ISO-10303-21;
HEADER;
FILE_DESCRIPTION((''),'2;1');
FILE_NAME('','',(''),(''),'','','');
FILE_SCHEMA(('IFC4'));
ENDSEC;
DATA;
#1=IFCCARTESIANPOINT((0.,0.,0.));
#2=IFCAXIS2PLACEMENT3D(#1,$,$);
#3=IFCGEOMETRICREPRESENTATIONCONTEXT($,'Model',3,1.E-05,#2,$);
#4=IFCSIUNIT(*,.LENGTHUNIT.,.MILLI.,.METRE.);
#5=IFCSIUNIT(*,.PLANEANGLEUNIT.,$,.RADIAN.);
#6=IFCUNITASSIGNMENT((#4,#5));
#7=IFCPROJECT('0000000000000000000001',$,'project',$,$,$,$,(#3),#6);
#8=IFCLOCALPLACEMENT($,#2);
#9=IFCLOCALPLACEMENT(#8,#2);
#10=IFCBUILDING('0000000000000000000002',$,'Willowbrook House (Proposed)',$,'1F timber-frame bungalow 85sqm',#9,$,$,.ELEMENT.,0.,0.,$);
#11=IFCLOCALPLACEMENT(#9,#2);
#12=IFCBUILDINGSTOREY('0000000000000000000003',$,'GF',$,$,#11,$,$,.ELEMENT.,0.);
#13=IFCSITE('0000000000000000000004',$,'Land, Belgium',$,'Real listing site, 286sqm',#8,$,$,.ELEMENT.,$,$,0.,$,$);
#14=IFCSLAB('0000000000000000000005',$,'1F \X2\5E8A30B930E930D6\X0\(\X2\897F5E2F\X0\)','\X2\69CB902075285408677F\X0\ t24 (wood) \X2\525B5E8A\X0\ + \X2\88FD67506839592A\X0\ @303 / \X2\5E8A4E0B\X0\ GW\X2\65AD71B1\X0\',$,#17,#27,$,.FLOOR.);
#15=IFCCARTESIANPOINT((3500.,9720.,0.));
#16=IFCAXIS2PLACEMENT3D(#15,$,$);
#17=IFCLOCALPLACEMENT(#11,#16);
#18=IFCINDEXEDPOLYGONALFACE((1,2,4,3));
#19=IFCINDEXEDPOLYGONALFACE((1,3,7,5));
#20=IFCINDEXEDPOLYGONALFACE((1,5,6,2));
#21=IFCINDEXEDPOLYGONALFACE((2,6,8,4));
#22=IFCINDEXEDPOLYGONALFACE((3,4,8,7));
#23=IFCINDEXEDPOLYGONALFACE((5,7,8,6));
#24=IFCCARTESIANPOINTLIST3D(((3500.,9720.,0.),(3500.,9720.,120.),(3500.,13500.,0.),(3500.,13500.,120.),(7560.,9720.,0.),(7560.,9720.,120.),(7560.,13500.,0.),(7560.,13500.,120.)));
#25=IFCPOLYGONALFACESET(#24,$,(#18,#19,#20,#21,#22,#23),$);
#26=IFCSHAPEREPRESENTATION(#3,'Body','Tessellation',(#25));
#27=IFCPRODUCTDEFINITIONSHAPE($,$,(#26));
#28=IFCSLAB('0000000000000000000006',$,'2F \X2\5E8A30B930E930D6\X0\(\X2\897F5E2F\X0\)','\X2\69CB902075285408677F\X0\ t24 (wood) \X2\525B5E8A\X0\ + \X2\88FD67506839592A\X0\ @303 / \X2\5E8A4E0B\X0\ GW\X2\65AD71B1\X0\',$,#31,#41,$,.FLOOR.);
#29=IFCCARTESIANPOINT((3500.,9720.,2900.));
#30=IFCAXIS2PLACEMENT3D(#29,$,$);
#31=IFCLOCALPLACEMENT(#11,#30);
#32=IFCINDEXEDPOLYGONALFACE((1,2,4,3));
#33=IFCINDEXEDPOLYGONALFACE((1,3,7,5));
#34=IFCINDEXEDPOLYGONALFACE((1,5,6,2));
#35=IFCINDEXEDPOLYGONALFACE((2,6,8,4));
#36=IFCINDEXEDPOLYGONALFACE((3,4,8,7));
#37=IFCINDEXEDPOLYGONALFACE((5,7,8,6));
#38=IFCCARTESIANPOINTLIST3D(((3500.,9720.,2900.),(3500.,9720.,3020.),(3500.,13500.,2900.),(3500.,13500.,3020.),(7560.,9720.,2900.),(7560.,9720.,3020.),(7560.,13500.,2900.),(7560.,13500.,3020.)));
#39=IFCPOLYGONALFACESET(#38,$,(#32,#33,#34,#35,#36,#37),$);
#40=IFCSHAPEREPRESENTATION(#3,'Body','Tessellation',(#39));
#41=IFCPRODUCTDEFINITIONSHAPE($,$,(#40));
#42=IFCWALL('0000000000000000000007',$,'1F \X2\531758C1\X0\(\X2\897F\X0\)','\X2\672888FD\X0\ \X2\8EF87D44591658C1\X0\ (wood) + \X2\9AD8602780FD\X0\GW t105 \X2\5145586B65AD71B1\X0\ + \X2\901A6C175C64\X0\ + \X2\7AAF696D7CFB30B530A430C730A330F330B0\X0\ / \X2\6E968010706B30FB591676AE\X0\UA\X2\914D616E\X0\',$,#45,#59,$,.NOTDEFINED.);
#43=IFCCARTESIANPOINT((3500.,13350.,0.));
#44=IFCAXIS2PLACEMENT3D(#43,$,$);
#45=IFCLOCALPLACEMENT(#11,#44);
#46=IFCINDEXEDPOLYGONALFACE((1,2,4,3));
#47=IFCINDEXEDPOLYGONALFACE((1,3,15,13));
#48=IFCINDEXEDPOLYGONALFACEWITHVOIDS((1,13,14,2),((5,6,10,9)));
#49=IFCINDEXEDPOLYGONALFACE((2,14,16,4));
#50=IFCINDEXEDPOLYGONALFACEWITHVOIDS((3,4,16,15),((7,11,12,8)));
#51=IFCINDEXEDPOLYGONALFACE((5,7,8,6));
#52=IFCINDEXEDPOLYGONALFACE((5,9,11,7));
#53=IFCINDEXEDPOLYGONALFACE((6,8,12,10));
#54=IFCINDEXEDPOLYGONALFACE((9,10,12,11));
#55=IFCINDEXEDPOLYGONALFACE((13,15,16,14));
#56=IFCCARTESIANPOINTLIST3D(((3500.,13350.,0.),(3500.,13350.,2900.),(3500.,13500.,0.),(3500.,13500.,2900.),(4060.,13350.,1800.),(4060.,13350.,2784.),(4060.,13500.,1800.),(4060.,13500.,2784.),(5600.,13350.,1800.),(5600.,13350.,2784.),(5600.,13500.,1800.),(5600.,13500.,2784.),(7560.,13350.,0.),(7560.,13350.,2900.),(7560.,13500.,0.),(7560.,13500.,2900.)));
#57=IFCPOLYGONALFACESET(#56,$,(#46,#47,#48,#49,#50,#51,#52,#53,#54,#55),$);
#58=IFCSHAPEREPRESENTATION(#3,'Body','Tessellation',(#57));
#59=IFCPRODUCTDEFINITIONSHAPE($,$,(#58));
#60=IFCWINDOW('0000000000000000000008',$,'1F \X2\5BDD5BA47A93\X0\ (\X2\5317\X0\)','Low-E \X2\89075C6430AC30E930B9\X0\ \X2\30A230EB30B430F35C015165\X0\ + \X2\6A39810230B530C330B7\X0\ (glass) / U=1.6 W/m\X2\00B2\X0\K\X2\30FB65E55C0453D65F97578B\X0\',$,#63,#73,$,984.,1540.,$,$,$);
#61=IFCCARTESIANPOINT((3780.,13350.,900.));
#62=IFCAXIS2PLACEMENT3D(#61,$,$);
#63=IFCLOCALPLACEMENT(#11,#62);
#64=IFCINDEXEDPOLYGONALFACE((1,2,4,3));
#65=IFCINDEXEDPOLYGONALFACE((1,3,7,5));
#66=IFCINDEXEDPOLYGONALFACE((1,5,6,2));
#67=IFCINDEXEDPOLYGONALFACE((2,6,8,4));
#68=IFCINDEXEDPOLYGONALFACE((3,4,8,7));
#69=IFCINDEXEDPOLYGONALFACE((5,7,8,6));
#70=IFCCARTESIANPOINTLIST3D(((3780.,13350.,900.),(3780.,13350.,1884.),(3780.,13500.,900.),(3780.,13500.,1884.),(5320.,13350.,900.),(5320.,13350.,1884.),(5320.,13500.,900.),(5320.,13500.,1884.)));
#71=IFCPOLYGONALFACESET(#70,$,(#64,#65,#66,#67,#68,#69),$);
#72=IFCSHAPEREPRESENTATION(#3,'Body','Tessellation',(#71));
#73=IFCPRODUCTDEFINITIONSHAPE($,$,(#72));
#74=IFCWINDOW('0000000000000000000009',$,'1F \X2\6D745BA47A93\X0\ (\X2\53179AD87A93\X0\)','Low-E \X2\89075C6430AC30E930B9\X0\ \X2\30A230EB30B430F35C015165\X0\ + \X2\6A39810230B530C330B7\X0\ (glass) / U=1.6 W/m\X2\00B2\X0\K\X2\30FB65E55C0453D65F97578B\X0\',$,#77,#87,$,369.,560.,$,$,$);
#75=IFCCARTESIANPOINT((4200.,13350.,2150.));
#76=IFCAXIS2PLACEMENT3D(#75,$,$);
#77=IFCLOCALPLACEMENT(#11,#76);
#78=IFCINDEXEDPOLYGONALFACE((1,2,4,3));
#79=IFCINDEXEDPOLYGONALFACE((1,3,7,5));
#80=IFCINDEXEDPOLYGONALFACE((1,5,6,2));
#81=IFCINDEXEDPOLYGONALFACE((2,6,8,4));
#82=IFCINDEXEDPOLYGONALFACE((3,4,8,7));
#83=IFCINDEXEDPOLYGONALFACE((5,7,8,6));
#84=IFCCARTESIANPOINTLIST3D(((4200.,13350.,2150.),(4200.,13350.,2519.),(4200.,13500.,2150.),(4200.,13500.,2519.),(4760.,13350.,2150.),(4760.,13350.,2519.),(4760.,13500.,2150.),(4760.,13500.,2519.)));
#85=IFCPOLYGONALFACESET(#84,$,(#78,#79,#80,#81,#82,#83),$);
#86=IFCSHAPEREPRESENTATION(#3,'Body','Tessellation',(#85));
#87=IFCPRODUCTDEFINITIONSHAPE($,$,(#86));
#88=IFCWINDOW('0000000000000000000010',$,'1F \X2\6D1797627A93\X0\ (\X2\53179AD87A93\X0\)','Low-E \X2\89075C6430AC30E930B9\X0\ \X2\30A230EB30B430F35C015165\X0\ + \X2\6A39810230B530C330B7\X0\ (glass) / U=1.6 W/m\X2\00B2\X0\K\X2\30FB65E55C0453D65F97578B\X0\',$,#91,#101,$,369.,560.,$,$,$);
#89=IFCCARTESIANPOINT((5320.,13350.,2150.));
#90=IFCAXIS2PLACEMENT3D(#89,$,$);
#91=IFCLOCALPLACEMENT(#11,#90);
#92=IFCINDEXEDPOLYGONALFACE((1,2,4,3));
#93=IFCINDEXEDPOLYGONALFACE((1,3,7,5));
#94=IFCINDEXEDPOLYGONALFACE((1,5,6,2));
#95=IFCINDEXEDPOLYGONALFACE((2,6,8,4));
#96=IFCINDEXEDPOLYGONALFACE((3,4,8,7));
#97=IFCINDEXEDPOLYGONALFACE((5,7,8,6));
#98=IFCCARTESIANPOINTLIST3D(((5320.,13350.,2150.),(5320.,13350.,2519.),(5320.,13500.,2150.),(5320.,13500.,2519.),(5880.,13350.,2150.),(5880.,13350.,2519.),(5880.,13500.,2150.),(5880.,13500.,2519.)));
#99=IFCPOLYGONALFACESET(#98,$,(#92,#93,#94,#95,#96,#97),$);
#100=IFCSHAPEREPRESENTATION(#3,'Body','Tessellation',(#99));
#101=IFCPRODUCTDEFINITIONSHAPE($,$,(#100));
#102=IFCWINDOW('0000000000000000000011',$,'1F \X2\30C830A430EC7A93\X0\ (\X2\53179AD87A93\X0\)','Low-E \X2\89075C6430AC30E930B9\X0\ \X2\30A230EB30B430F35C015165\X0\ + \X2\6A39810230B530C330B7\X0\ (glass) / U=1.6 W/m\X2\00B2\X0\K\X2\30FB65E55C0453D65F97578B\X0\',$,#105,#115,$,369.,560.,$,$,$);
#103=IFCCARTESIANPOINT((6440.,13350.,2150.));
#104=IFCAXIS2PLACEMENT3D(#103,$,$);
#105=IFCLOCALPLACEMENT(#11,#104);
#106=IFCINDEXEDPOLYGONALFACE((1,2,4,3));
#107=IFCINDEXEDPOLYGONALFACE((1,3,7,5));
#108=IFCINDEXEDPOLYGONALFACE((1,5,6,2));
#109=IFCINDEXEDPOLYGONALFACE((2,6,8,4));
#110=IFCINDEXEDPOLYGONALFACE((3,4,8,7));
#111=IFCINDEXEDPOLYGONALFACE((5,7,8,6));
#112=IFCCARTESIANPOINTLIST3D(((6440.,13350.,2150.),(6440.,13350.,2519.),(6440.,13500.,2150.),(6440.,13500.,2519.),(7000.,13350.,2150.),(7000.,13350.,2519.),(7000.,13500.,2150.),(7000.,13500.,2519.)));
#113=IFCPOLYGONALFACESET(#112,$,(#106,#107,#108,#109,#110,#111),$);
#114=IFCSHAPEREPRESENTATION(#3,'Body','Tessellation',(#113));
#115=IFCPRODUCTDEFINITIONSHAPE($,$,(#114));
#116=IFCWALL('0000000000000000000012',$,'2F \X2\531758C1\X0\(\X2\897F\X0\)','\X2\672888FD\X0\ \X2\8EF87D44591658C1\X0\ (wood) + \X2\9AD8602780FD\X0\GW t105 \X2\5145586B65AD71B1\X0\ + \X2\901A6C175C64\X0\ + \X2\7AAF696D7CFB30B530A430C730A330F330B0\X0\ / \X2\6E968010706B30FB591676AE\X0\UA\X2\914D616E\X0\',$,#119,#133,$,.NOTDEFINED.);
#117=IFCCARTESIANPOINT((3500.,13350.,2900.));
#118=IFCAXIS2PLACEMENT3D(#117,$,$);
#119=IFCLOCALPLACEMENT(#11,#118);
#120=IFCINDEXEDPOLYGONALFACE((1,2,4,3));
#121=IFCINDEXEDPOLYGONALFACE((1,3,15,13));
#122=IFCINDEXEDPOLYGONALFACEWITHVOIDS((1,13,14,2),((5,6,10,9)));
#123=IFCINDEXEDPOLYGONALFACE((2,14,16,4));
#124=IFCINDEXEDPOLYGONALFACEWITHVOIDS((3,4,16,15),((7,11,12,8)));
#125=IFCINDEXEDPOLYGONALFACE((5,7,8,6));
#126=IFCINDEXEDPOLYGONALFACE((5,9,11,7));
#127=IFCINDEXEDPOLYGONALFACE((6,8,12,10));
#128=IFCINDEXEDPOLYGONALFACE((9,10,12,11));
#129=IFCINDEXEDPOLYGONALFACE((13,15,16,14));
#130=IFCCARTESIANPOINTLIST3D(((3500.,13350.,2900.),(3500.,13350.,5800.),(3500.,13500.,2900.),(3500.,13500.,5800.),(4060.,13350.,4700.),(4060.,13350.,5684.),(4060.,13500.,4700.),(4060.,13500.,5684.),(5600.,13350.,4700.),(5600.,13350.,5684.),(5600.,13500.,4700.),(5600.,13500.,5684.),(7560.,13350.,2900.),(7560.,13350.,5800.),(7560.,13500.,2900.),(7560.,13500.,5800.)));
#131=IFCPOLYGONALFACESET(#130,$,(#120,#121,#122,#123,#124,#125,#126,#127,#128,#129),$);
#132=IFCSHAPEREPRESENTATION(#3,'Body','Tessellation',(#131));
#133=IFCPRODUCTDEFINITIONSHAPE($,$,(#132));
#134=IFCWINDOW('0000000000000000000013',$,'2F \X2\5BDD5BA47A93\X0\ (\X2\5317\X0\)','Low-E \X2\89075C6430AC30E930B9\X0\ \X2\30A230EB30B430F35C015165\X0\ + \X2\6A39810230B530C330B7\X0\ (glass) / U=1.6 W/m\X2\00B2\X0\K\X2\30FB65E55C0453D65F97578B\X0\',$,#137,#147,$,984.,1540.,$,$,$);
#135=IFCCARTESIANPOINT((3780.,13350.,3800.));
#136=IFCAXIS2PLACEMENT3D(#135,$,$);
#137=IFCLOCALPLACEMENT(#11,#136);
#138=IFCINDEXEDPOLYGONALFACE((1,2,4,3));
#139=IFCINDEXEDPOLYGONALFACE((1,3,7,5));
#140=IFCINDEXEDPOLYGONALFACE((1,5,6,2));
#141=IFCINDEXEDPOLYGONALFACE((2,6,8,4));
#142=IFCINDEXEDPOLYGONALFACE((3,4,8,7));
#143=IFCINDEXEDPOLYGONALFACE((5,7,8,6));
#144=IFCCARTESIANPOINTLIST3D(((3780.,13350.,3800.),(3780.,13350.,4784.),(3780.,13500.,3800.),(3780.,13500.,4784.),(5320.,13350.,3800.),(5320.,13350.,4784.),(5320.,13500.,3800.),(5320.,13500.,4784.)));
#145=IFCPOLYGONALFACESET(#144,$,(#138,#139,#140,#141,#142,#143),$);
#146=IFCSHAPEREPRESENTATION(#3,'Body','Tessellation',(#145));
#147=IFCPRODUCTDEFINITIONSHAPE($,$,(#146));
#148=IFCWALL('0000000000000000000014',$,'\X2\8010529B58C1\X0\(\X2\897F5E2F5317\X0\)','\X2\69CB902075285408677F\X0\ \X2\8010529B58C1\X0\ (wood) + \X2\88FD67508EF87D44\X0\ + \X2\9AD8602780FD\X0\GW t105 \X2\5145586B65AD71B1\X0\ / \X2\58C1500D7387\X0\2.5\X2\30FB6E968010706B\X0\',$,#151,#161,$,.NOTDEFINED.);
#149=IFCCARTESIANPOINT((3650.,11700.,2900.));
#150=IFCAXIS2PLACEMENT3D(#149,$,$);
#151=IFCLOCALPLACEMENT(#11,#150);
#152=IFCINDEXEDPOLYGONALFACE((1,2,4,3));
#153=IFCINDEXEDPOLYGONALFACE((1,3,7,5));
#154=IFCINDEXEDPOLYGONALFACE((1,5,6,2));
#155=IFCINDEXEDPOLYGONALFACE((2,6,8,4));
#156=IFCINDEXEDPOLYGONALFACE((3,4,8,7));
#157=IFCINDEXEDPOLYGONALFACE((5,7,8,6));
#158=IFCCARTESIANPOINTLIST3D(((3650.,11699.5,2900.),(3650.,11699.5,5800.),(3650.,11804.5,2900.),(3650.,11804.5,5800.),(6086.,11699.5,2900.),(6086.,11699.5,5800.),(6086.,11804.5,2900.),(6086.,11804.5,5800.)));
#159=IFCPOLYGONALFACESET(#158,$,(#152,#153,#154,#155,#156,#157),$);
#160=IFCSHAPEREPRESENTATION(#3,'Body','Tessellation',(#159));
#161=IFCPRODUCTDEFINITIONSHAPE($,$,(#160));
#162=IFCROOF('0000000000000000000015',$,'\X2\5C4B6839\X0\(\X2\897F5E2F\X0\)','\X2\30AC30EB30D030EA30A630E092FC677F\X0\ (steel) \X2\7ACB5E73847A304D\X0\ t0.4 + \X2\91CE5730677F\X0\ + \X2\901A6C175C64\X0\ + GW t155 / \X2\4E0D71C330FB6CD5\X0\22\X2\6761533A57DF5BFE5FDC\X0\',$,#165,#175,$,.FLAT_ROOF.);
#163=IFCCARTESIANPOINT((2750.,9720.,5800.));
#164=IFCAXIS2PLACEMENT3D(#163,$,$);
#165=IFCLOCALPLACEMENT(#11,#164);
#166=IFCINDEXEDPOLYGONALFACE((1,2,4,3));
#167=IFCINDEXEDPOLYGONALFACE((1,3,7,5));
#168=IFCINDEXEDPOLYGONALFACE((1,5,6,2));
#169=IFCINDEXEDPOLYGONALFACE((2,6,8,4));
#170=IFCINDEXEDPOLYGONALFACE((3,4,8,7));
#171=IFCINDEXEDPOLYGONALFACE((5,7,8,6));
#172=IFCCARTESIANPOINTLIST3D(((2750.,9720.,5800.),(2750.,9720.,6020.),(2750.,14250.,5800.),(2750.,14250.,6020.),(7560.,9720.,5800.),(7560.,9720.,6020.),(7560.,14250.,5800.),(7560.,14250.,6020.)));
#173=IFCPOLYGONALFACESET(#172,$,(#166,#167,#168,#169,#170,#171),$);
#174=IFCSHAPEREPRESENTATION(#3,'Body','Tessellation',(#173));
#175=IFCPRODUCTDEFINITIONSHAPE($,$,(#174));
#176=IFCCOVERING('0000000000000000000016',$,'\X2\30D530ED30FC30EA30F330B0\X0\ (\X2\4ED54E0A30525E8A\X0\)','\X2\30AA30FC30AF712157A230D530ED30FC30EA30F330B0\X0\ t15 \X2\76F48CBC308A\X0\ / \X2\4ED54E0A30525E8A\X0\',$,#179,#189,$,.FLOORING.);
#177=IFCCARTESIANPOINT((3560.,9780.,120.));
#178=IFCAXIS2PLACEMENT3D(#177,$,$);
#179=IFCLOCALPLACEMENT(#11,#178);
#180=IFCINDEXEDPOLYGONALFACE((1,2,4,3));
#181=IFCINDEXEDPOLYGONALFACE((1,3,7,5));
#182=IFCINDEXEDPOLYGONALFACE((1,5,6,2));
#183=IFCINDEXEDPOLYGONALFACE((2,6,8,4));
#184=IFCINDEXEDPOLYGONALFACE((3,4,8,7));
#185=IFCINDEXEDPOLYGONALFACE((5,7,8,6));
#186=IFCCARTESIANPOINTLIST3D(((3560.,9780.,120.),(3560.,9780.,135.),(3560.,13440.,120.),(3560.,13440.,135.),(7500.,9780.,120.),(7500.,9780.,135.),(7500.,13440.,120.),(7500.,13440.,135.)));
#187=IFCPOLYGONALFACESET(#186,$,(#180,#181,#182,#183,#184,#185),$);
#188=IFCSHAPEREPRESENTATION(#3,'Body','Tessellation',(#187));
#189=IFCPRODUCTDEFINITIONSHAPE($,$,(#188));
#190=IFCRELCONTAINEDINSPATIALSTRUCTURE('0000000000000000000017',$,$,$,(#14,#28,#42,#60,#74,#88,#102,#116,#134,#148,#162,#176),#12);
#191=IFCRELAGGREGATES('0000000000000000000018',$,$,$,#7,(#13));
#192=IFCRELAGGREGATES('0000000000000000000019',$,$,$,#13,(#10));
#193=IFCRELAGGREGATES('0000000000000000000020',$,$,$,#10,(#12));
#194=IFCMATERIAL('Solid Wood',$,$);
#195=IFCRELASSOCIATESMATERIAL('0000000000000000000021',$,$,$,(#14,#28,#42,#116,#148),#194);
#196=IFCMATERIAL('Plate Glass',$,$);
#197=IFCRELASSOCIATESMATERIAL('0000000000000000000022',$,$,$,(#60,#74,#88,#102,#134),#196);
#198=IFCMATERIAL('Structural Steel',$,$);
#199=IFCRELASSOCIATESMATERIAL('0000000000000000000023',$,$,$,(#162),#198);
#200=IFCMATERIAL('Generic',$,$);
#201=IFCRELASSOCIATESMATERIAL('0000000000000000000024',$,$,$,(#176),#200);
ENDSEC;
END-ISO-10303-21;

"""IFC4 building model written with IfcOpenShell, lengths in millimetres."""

from ifc_helpers import new_model, si_unit, frame, frame_2d, origin, place, context, project, spatial, rectangle, extrude, material, element, fill, save


model = new_model("IFC4")

# Units and contexts
model_context = context("Model", 3, precision=1e-05, world=origin())
ifc_project = project(units=[si_unit("LENGTHUNIT", "METRE", prefix="MILLI"), si_unit("PLANEANGLEUNIT", "RADIAN")], contexts=[model_context])

# Site, building, storey
site_placement = place(None, origin())
site = spatial("IfcSite", under=ifc_project, at=site_placement, Name="Land, Belgium", ObjectType="Real listing site, 286sqm", CompositionType="ELEMENT", RefElevation=0.0)
building_placement = place(site_placement, origin())
building = spatial("IfcBuilding", under=site, at=building_placement, Name="Willowbrook House (Proposed)", ObjectType="1F timber-frame bungalow 85sqm", CompositionType="ELEMENT", ElevationOfRefHeight=0.0, ElevationOfTerrain=0.0)
storey_placement = place(building_placement, origin())
storey = spatial("IfcBuildingStorey", under=building, at=storey_placement, Name="GF", CompositionType="ELEMENT", Elevation=0.0)

# Slabs
ifc_material_1 = material(Name="Solid Wood")
slab_1_placement = place(storey_placement, frame((3500.0, 9720.0, 0.0)))
element("IfcSlab", 1, at=slab_1_placement, inside=storey, material=ifc_material_1, Name="1F 床スラブ(西帯)", Description="構造用合板 t24 (wood) 剛床 + 製材根太 @303 / 床下 GW断熱", PredefinedType="FLOOR", context=model_context, shape_type="SweptSolid", body=[
    extrude(rectangle(XDim=4060.0, YDim=3780.0, at=frame_2d((2030.0, 1890.0))), frame((3500.0, 9720.0, 0.0)), (0.0, 0.0, 1.0), 120.0),
])
slab_2_placement = place(storey_placement, frame((3500.0, 9720.0, 2900.0)))
element("IfcSlab", 2, at=slab_2_placement, inside=storey, material=ifc_material_1, Name="2F 床スラブ(西帯)", Description="構造用合板 t24 (wood) 剛床 + 製材根太 @303 / 床下 GW断熱", PredefinedType="FLOOR", context=model_context, shape_type="SweptSolid", body=[
    extrude(rectangle(XDim=4060.0, YDim=3780.0, at=frame_2d((2030.0, 1890.0))), frame((3500.0, 9720.0, 2900.0)), (0.0, 0.0, 1.0), 120.0),
])

# Wall, openings, windows
wall_1_placement = place(storey_placement, frame((3500.0, 13350.0, 0.0)))
wall_1 = element("IfcWall", 3, at=wall_1_placement, inside=storey, material=ifc_material_1, Name="1F 北壁(西)", Description="木製 軸組外壁 (wood) + 高性能GW t105 充填断熱 + 通気層 + 窯業系サイディング / 準耐火・外皮UA配慮", PredefinedType="NOTDEFINED", context=model_context, shape_type="SweptSolid", body=[
    extrude(rectangle(XDim=4060.0, YDim=150.0, at=frame_2d((2030.0, 75.0))), frame((3500.0, 13350.0, 0.0)), (0.0, 0.0, 1.0), 2900.0),
])
opening_1_placement = place(storey_placement, frame((3780.0, 13350.0, 900.0)))
opening_1 = element("IfcOpeningElement", 4, at=opening_1_placement, cuts=wall_1, PredefinedType="NOTDEFINED", context=model_context, shape_type="SweptSolid", body=[
    extrude(rectangle(XDim=1540.0, YDim=150.0, at=frame_2d((770.0, 75.0))), frame((3780.0, 13350.0, 900.0)), (0.0, 0.0, 1.0), 984.0),
])
opening_2_placement = place(storey_placement, frame((4200.0, 13350.0, 2150.0)))
opening_2 = element("IfcOpeningElement", 5, at=opening_2_placement, cuts=wall_1, PredefinedType="NOTDEFINED", context=model_context, shape_type="SweptSolid", body=[
    extrude(rectangle(XDim=560.0, YDim=150.0, at=frame_2d((280.0, 75.0))), frame((4200.0, 13350.0, 2150.0)), (0.0, 0.0, 1.0), 369.0),
])
opening_3_placement = place(storey_placement, frame((5320.0, 13350.0, 2150.0)))
opening_3 = element("IfcOpeningElement", 6, at=opening_3_placement, cuts=wall_1, PredefinedType="NOTDEFINED", context=model_context, shape_type="SweptSolid", body=[
    extrude(rectangle(XDim=560.0, YDim=150.0, at=frame_2d((280.0, 75.0))), frame((5320.0, 13350.0, 2150.0)), (0.0, 0.0, 1.0), 369.0),
])
opening_4_placement = place(storey_placement, frame((6440.0, 13350.0, 2150.0)))
opening_4 = element("IfcOpeningElement", 7, at=opening_4_placement, cuts=wall_1, PredefinedType="NOTDEFINED", context=model_context, shape_type="SweptSolid", body=[
    extrude(rectangle(XDim=560.0, YDim=150.0, at=frame_2d((280.0, 75.0))), frame((6440.0, 13350.0, 2150.0)), (0.0, 0.0, 1.0), 369.0),
])
ifc_material_2 = material(Name="Plate Glass")
window_1_placement = place(storey_placement, frame((3780.0, 13350.0, 900.0)))
window_1 = element("IfcWindow", 8, at=window_1_placement, inside=storey, material=ifc_material_2, Name="1F 寝室窓 (北)", Description="Low-E 複層ガラス アルゴン封入 + 樹脂サッシ (glass) / U=1.6 W/m²K・日射取得型", OverallHeight=984.0, OverallWidth=1540.0, context=model_context, shape_type="SweptSolid", body=[
    extrude(rectangle(XDim=1540.0, YDim=150.0, at=frame_2d((770.0, 75.0))), frame((3780.0, 13350.0, 900.0)), (0.0, 0.0, 1.0), 984.0),
])
fill(opening_1, window_1)
window_2_placement = place(storey_placement, frame((4200.0, 13350.0, 2150.0)))
window_2 = element("IfcWindow", 9, at=window_2_placement, inside=storey, material=ifc_material_2, Name="1F 浴室窓 (北高窓)", Description="Low-E 複層ガラス アルゴン封入 + 樹脂サッシ (glass) / U=1.6 W/m²K・日射取得型", OverallHeight=369.0, OverallWidth=560.0, context=model_context, shape_type="SweptSolid", body=[
    extrude(rectangle(XDim=560.0, YDim=150.0, at=frame_2d((280.0, 75.0))), frame((4200.0, 13350.0, 2150.0)), (0.0, 0.0, 1.0), 369.0),
])
fill(opening_2, window_2)
window_3_placement = place(storey_placement, frame((5320.0, 13350.0, 2150.0)))
window_3 = element("IfcWindow", 10, at=window_3_placement, inside=storey, material=ifc_material_2, Name="1F 洗面窓 (北高窓)", Description="Low-E 複層ガラス アルゴン封入 + 樹脂サッシ (glass) / U=1.6 W/m²K・日射取得型", OverallHeight=369.0, OverallWidth=560.0, context=model_context, shape_type="SweptSolid", body=[
    extrude(rectangle(XDim=560.0, YDim=150.0, at=frame_2d((280.0, 75.0))), frame((5320.0, 13350.0, 2150.0)), (0.0, 0.0, 1.0), 369.0),
])
fill(opening_3, window_3)
window_4_placement = place(storey_placement, frame((6440.0, 13350.0, 2150.0)))
window_4 = element("IfcWindow", 11, at=window_4_placement, inside=storey, material=ifc_material_2, Name="1F トイレ窓 (北高窓)", Description="Low-E 複層ガラス アルゴン封入 + 樹脂サッシ (glass) / U=1.6 W/m²K・日射取得型", OverallHeight=369.0, OverallWidth=560.0, context=model_context, shape_type="SweptSolid", body=[
    extrude(rectangle(XDim=560.0, YDim=150.0, at=frame_2d((280.0, 75.0))), frame((6440.0, 13350.0, 2150.0)), (0.0, 0.0, 1.0), 369.0),
])
fill(opening_4, window_4)

# Wall, opening, window
wall_2_placement = place(storey_placement, frame((3500.0, 13350.0, 2900.0)))
wall_2 = element("IfcWall", 12, at=wall_2_placement, inside=storey, material=ifc_material_1, Name="2F 北壁(西)", Description="木製 軸組外壁 (wood) + 高性能GW t105 充填断熱 + 通気層 + 窯業系サイディング / 準耐火・外皮UA配慮", PredefinedType="NOTDEFINED", context=model_context, shape_type="SweptSolid", body=[
    extrude(rectangle(XDim=4060.0, YDim=150.0, at=frame_2d((2030.0, 75.0))), frame((3500.0, 13350.0, 2900.0)), (0.0, 0.0, 1.0), 2900.0),
])
opening_5_placement = place(storey_placement, frame((3780.0, 13350.0, 3800.0)))
opening_5 = element("IfcOpeningElement", 13, at=opening_5_placement, cuts=wall_2, PredefinedType="NOTDEFINED", context=model_context, shape_type="SweptSolid", body=[
    extrude(rectangle(XDim=1540.0, YDim=150.0, at=frame_2d((770.0, 75.0))), frame((3780.0, 13350.0, 3800.0)), (0.0, 0.0, 1.0), 984.0),
])
window_5_placement = place(storey_placement, frame((3780.0, 13350.0, 3800.0)))
window_5 = element("IfcWindow", 14, at=window_5_placement, inside=storey, material=ifc_material_2, Name="2F 寝室窓 (北)", Description="Low-E 複層ガラス アルゴン封入 + 樹脂サッシ (glass) / U=1.6 W/m²K・日射取得型", OverallHeight=984.0, OverallWidth=1540.0, context=model_context, shape_type="SweptSolid", body=[
    extrude(rectangle(XDim=1540.0, YDim=150.0, at=frame_2d((770.0, 75.0))), frame((3780.0, 13350.0, 3800.0)), (0.0, 0.0, 1.0), 984.0),
])
fill(opening_5, window_5)

# Wall
wall_3_placement = place(storey_placement, frame((3650.0, 11700.0, 2900.0)))
element("IfcWall", 15, at=wall_3_placement, inside=storey, material=ifc_material_1, Name="耐力壁(西帯北)", Description="構造用合板 耐力壁 (wood) + 製材軸組 + 高性能GW t105 充填断熱 / 壁倍率2.5・準耐火", PredefinedType="NOTDEFINED", context=model_context, shape_type="SweptSolid", body=[
    extrude(rectangle(XDim=2436.0, YDim=105.0, at=frame_2d((1218.0, 52.0))), frame((3650.0, 11700.0, 2900.0)), (0.0, 0.0, 1.0), 2900.0),
])

# Roof
ifc_material_3 = material(Name="Structural Steel")
for number, where, name in (
    (16, (2750.0, 9720.0, 5800.0), "屋根(西帯)"),
):
    element("IfcRoof", number, at=place(storey_placement, frame(where)), inside=storey, material=ifc_material_3, Name=name, Description="ガルバリウム鋼板 (steel) 立平葺き t0.4 + 野地板 + 通気層 + GW t155 / 不燃・法22条区域対応", PredefinedType="FLAT_ROOF", context=model_context, shape_type="SweptSolid", body=[
        extrude(rectangle(XDim=4810.0, YDim=4530.0, at=frame_2d((2405.0, 2265.0))), frame((2750.0, 9720.0, 5800.0)), (0.0, 0.0, 1.0), 220.0),
    ])

# Covering
ifc_material_4 = material(Name="Generic")
covering_1_placement = place(storey_placement, frame((3560.0, 9780.0, 120.0)))
element("IfcCovering", 17, at=covering_1_placement, inside=storey, material=ifc_material_4, Name="フローリング (仕上げ床)", Description="オーク無垢フローリング t15 直貼り / 仕上げ床", PredefinedType="FLOORING", context=model_context, shape_type="SweptSolid", body=[
    extrude(rectangle(XDim=3940.0, YDim=3660.0, at=frame_2d((1970.0, 1830.0))), frame((3560.0, 9780.0, 120.0)), (0.0, 0.0, 1.0), 15.0),
])

save(model, "model.ifc")
